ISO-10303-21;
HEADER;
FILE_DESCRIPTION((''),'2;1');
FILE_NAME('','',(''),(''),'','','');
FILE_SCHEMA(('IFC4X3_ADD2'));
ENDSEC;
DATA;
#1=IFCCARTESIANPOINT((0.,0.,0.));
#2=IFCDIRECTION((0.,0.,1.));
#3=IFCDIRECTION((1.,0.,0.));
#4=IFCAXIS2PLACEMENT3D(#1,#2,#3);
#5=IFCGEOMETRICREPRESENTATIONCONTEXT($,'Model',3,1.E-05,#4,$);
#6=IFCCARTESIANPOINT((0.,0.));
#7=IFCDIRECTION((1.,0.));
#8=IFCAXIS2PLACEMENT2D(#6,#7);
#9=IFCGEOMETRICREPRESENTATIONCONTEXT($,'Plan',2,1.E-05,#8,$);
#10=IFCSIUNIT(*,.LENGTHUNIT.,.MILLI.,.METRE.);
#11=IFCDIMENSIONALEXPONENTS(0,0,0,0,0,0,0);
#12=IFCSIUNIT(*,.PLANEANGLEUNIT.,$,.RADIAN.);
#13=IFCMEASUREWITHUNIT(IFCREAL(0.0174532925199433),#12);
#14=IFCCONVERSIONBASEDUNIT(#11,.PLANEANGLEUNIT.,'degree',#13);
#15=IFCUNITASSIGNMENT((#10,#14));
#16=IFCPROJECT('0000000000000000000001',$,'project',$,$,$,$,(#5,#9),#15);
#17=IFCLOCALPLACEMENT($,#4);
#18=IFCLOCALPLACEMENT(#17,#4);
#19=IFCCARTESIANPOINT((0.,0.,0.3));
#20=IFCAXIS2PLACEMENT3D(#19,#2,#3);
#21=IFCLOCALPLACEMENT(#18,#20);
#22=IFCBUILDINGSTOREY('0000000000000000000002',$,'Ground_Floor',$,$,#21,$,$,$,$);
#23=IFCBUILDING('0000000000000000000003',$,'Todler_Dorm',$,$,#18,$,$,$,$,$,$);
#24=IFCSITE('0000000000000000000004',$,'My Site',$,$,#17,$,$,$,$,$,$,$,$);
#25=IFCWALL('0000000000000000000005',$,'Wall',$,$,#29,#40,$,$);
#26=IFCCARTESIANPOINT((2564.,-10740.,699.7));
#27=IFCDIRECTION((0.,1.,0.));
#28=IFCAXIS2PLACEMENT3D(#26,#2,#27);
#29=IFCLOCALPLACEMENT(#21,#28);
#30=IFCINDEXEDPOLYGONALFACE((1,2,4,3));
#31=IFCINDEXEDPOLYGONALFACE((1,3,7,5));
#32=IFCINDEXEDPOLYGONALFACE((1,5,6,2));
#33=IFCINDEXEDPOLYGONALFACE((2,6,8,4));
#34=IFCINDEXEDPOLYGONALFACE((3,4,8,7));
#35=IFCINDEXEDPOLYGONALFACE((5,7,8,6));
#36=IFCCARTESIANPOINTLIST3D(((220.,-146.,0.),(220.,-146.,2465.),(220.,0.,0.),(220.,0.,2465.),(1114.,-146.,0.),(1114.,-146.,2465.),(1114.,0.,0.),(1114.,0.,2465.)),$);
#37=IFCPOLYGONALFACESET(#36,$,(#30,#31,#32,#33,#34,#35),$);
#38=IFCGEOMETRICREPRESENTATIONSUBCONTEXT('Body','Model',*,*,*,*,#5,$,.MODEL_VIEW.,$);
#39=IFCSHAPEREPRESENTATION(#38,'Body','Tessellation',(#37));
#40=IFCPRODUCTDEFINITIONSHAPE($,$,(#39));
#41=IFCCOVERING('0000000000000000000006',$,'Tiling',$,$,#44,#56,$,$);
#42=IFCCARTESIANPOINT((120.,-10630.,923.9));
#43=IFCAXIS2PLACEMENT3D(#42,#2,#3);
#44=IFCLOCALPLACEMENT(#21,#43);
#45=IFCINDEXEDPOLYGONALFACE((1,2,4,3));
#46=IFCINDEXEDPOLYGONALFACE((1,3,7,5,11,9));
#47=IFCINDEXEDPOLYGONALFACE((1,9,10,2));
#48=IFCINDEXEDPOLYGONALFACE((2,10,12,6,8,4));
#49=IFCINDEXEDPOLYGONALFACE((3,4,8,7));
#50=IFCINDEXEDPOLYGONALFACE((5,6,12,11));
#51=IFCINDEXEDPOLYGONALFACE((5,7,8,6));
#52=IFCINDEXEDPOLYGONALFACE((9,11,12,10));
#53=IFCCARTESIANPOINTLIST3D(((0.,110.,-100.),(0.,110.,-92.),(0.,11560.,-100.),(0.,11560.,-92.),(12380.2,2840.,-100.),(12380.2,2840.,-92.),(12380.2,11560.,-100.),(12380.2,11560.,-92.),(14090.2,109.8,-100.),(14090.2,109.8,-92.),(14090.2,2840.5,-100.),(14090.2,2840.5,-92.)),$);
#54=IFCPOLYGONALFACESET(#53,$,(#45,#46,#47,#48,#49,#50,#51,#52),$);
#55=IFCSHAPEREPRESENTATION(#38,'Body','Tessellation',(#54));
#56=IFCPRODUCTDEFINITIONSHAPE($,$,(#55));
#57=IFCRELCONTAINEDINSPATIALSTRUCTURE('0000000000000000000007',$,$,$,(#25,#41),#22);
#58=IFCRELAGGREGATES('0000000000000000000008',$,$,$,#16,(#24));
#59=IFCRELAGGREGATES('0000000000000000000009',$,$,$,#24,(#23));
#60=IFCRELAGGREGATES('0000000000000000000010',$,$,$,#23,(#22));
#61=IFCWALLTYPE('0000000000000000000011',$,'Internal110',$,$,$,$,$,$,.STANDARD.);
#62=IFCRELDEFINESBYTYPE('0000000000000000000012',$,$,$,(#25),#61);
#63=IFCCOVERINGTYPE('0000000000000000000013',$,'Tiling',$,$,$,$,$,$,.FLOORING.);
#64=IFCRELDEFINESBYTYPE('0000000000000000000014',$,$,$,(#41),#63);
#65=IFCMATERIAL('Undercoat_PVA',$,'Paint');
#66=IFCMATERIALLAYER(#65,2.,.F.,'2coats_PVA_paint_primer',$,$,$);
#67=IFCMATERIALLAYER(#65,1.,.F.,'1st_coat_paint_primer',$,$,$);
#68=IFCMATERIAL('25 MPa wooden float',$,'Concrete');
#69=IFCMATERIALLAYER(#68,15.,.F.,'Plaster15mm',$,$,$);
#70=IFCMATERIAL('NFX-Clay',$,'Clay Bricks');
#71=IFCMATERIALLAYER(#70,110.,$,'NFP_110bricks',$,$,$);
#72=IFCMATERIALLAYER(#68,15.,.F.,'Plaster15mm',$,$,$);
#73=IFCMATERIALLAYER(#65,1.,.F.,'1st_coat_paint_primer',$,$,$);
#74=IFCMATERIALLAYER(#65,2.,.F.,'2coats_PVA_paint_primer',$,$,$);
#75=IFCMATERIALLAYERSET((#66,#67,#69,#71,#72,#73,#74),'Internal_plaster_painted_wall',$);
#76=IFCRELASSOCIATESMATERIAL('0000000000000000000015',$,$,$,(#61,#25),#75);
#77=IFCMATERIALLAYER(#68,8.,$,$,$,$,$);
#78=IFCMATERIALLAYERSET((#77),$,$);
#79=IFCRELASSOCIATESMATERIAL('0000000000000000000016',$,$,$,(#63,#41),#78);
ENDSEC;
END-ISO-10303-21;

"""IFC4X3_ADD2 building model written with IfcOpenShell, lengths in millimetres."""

from ifc_helpers import new_model, entity, si_unit, converted_unit, frame, origin_with_axes, origin_2d_with_axis, place, context, subcontext, project, spatial, line, indexed_curve, outline, extrude, material, layer, layer_set, layer_usage, type_object, element, save


model = new_model("IFC4X3_ADD2")

# Units and contexts
model_context = context("Model", 3, precision=1e-05, world=origin_with_axes())
plan_context = context("Plan", 2, precision=1e-05, world=origin_2d_with_axis())
body_context_1 = subcontext(model_context, "Body", "Model", "MODEL_VIEW")
ifc_project = project(units=[si_unit("LENGTHUNIT", "METRE", prefix="MILLI"), converted_unit("PLANEANGLEUNIT", "degree", entity("IfcReal", 0.0174532925199433), si_unit("PLANEANGLEUNIT", "RADIAN"), dimensions=[0, 0, 0, 0, 0, 0, 0])], contexts=[model_context, plan_context])

# Site, building, storey
site_placement = place(None, origin_with_axes())
site = spatial("IfcSite", under=ifc_project, at=site_placement, Name="My Site")
building_placement = place(site_placement, origin_with_axes())
building = spatial("IfcBuilding", under=site, at=building_placement, Name="Todler_Dorm")
storey_placement = place(building_placement, frame((0.0, 0.0, 0.3), z_axis=(0.0, 0.0, 1.0), x_axis=(1.0, 0.0, 0.0)))
storey = spatial("IfcBuildingStorey", under=building, at=storey_placement, Name="Ground_Floor")

# Shared definitions
ifc_material_1 = material(Name="Undercoat_PVA", Category="Paint")
ifc_layer_1 = layer(ifc_material_1, 2.0, ventilated=False, Name="2coats_PVA_paint_primer")
ifc_layer_2 = layer(ifc_material_1, 1.0, ventilated=False, Name="1st_coat_paint_primer")
ifc_material_2 = material(Name="25 MPa wooden float", Category="Concrete")
ifc_layer_3 = layer(ifc_material_2, 15.0, ventilated=False, Name="Plaster15mm")
ifc_material_3 = material(Name="NFX-Clay", Category="Clay Bricks")
ifc_layer_4 = layer(ifc_material_3, 110.0, Name="NFP_110bricks")
ifc_layer_5 = layer(ifc_material_2, 15.0, ventilated=False, Name="Plaster15mm")
ifc_layer_6 = layer(ifc_material_1, 1.0, ventilated=False, Name="1st_coat_paint_primer")
ifc_layer_7 = layer(ifc_material_1, 2.0, ventilated=False, Name="2coats_PVA_paint_primer")
ifc_layer_set_1 = layer_set([ifc_layer_1, ifc_layer_2, ifc_layer_3, ifc_layer_4, ifc_layer_5, ifc_layer_6, ifc_layer_7], Name="Internal_plaster_painted_wall")
wall_type_1 = type_object("IfcWallType", Name="Internal110", PredefinedType="STANDARD", material=ifc_layer_set_1)

# Wall
ifc_layer_usage_1 = layer_usage(ifc_layer_set_1, "AXIS2", "NEGATIVE", 0.0)
wall_1_placement = place(storey_placement, frame((2564.0, -10740.0, 699.7), z_axis=(0.0, 0.0, 1.0), x_axis=(0.0, 1.0, 0.0)))
element("IfcWall", 1, at=wall_1_placement, inside=storey, type_object=wall_type_1, material=ifc_layer_usage_1, Name="Wall", context=body_context_1, shape_type="SweptSolid", body=[
    extrude(outline(indexed_curve([(220.0, -146.0), (220.0, 0.0), (1114.0, 0.0), (1114.0, -146.0)], segments=[line(1, 2, 3, 4, 1)])), origin_with_axes(), (0.0, 0.0, 1.0), 2465.0),
])

# Covering
ifc_layer_8 = layer(ifc_material_2, 8.0)
ifc_layer_set_2 = layer_set([ifc_layer_8])
ifc_layer_usage_2 = layer_usage(ifc_layer_set_2, "AXIS3", "POSITIVE", -100.0)
covering_type = type_object("IfcCoveringType", Name="Tiling", PredefinedType="FLOORING", material=ifc_layer_set_2)
covering_placement = place(storey_placement, frame((120.0, -10630.0, 923.9), z_axis=(0.0, 0.0, 1.0), x_axis=(1.0, 0.0, 0.0)))
element("IfcCovering", 2, at=covering_placement, inside=storey, type_object=covering_type, material=ifc_layer_usage_2, Name="Tiling", context=body_context_1, shape_type="SweptSolid", body=[
    extrude(outline(indexed_curve([(12380.2, 11560.0), (0.0, 11560.0), (0.0, 110.0), (14090.2, 109.8), (14090.2, 2840.5), (12380.2, 2840.0), (12380.2, 11560.0)])), frame((0.0, 0.0, -100.0), z_axis=(0.0, 0.0, 1.0), x_axis=(1.0, 0.0, 0.0)), (0.0, 0.0, 1.0), 8.0),
])

save(model, "model.ifc")
